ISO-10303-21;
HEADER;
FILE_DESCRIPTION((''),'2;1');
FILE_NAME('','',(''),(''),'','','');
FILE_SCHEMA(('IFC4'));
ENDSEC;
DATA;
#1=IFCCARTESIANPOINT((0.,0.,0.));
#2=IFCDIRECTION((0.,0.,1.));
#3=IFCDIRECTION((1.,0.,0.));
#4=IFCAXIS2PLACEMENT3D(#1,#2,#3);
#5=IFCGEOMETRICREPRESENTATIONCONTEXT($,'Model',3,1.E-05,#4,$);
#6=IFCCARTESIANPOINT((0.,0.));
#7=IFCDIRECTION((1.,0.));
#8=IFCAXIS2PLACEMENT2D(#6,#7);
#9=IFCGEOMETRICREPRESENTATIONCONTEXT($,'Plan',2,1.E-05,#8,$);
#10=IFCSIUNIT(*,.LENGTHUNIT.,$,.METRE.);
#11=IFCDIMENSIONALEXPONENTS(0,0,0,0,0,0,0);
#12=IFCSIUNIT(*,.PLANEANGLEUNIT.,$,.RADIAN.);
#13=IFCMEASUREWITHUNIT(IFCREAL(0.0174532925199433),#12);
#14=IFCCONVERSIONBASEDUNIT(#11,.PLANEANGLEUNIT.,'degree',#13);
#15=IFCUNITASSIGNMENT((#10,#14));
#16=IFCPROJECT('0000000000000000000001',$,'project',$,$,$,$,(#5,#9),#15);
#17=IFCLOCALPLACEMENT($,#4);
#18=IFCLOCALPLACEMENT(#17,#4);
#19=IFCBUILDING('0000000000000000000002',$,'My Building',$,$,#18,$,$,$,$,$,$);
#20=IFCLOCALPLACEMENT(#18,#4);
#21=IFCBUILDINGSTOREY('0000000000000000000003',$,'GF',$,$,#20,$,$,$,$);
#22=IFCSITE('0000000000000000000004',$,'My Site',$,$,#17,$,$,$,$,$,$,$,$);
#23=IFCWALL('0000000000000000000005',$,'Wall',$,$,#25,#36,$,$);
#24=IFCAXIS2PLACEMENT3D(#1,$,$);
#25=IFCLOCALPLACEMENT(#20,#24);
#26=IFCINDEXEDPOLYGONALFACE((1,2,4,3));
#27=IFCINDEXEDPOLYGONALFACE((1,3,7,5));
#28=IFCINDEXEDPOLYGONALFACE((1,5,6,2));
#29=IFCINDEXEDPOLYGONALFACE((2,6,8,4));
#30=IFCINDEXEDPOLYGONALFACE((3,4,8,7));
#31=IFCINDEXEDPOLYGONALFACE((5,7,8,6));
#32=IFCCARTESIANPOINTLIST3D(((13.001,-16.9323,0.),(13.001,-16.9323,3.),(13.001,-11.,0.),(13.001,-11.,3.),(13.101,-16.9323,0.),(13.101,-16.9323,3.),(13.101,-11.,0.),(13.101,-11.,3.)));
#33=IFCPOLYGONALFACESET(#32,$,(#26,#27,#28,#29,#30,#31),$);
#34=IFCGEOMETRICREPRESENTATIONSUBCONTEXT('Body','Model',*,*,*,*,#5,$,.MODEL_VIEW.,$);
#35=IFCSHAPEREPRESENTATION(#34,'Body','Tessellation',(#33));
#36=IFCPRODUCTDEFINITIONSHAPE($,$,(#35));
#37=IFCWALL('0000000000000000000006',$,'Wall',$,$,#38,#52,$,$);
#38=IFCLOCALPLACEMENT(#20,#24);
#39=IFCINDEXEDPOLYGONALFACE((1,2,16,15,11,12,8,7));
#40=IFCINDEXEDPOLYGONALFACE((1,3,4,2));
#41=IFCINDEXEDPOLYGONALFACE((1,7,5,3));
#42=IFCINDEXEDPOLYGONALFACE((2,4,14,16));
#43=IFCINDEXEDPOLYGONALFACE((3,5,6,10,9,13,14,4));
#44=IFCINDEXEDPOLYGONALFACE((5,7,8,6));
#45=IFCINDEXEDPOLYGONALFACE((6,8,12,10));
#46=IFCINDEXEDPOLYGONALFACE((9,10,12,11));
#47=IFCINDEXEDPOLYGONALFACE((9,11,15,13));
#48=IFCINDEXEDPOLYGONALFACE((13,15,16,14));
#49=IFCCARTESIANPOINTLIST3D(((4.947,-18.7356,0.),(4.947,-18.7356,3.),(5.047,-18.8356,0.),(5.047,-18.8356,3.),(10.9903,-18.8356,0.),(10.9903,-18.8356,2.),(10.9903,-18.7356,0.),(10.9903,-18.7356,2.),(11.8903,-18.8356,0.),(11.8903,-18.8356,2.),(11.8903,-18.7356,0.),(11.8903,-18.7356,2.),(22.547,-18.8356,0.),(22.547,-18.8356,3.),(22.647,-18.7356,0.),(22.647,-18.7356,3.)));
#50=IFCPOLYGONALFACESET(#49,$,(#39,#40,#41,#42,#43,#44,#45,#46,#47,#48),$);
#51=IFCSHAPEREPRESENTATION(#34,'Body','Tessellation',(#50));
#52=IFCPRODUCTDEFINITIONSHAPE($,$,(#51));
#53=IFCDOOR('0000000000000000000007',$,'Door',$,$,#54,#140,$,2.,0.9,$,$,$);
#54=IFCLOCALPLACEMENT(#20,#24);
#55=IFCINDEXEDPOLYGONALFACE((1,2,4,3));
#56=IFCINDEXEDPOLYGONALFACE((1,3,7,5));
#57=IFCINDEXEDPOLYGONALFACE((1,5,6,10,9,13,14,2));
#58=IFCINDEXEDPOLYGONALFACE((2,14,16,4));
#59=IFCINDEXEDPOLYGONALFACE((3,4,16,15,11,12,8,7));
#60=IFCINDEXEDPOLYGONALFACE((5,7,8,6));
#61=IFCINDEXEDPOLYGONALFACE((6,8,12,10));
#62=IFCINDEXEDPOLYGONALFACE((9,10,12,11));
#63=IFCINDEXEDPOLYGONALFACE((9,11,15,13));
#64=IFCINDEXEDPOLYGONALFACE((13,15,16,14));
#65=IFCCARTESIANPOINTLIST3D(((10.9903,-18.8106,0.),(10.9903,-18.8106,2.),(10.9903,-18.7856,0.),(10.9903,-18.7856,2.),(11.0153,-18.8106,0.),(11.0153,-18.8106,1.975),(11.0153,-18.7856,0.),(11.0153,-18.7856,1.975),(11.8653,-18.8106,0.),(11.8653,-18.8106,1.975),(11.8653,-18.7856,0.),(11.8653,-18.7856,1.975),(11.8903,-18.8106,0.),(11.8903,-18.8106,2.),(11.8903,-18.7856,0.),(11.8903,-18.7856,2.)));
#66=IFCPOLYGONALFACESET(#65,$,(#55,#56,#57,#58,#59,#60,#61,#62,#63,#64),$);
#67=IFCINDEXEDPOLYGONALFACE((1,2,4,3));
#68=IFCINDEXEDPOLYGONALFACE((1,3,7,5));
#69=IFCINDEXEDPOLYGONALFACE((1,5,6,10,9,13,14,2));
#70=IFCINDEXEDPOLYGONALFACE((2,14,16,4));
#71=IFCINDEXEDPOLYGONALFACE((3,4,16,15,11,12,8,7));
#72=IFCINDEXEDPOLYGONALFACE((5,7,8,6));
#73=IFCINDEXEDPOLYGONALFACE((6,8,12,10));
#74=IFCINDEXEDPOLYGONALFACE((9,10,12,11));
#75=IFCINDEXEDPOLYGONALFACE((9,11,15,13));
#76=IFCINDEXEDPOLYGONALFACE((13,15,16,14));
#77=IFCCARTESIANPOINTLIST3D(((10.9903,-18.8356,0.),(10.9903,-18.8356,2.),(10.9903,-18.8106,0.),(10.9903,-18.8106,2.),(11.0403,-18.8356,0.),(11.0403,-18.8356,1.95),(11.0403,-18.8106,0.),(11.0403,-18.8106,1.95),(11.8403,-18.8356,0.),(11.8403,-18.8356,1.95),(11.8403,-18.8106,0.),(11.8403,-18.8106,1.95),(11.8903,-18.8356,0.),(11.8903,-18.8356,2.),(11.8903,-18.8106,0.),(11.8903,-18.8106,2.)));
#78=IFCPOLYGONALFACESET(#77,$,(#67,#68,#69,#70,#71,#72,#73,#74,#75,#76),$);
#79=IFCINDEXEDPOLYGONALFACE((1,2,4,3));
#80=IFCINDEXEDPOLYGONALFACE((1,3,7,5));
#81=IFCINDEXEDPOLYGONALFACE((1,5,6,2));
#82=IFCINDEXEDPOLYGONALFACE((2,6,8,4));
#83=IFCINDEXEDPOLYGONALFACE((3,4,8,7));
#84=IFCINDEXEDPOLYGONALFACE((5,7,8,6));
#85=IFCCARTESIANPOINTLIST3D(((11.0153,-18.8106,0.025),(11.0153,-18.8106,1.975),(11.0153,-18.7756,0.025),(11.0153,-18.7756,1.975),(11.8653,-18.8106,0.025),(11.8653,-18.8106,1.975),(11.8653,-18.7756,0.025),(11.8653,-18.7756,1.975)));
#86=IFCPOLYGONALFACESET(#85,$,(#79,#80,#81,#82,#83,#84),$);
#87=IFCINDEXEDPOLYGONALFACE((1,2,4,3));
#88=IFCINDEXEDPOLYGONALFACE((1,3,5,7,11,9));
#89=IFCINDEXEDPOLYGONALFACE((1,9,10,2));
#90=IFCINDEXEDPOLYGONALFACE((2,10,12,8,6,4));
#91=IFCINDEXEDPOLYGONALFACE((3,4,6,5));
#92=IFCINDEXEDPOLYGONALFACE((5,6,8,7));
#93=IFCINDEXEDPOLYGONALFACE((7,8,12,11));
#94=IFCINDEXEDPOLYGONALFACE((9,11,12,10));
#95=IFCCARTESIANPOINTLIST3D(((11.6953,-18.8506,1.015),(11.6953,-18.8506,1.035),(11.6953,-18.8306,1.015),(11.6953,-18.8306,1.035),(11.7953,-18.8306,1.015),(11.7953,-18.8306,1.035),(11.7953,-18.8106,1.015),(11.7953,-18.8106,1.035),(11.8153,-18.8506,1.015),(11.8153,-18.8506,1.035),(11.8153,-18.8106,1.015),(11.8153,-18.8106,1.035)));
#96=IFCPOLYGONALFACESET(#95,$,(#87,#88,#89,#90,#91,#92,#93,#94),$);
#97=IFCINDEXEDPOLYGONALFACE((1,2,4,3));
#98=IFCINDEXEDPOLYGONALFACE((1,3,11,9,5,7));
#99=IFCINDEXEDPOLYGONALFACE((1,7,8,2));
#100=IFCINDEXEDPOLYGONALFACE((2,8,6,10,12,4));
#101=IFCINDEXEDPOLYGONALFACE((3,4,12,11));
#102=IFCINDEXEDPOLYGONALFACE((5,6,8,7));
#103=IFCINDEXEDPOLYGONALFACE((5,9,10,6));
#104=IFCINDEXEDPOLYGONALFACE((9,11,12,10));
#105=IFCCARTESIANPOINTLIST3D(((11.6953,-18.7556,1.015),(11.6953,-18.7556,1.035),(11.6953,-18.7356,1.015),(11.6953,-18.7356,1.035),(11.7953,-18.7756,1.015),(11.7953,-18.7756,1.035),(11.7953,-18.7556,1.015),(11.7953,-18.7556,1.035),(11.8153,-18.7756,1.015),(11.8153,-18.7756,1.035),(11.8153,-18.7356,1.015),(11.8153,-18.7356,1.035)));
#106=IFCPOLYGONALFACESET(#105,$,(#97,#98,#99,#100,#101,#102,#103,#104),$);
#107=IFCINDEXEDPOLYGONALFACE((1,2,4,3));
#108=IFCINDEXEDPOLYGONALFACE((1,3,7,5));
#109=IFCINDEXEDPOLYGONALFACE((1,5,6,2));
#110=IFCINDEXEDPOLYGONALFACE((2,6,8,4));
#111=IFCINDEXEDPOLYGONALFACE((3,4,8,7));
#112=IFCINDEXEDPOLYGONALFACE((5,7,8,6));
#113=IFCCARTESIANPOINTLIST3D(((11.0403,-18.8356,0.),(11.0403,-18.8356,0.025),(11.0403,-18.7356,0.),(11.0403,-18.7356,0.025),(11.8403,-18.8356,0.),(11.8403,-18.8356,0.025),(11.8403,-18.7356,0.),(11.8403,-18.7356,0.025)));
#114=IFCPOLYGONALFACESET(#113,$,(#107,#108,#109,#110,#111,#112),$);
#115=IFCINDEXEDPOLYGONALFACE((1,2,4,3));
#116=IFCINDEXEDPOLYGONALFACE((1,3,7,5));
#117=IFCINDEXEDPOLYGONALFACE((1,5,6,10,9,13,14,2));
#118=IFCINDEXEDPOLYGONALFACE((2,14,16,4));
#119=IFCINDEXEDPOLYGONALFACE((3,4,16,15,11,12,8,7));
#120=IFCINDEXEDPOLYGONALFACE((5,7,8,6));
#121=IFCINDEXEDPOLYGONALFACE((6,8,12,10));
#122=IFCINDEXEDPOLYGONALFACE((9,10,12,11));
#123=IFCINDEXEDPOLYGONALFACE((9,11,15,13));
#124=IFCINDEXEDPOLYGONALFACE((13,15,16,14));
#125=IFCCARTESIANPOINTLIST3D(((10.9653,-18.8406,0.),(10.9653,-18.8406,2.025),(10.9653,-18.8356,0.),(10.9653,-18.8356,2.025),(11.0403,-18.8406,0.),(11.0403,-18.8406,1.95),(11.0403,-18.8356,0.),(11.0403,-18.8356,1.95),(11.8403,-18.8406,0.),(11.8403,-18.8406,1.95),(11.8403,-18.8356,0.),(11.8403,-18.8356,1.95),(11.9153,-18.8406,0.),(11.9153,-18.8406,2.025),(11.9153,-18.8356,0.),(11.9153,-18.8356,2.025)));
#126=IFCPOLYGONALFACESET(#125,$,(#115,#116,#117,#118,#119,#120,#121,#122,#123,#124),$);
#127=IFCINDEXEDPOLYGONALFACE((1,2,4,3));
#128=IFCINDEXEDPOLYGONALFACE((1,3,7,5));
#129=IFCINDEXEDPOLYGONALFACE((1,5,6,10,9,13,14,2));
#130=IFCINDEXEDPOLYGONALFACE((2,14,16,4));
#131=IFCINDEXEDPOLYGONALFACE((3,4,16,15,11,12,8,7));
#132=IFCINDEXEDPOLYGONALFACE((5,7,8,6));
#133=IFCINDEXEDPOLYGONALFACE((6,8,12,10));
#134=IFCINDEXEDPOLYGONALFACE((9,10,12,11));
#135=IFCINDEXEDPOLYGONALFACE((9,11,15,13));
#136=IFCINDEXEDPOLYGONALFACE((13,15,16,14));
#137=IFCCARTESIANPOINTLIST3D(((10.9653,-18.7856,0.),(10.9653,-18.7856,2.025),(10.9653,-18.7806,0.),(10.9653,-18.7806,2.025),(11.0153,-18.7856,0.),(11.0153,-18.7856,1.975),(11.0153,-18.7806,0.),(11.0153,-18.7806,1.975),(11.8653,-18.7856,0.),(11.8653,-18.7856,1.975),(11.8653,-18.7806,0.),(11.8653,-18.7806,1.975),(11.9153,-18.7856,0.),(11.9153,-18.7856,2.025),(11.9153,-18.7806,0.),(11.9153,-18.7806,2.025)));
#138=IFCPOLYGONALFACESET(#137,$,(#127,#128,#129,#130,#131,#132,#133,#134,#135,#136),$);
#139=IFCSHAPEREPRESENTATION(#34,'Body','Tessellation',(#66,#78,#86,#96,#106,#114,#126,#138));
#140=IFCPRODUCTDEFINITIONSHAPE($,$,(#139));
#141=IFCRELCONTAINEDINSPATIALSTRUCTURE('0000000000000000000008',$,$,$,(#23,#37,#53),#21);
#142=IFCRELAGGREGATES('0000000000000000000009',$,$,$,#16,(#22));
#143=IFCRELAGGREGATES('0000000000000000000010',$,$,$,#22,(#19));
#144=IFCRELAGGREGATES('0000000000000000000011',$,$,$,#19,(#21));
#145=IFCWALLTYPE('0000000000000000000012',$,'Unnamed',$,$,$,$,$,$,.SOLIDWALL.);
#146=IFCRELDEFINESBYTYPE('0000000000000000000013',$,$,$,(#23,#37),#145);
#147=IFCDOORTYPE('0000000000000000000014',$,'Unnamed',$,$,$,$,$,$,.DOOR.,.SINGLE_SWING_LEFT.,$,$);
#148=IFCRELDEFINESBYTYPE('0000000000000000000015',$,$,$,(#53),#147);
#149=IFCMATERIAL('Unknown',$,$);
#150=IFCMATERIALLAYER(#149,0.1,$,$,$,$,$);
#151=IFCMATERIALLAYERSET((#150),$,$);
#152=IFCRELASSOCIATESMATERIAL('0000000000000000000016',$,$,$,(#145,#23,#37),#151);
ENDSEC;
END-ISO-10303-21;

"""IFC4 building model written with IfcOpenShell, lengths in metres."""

from ifc_helpers import new_model, entity, si_unit, converted_unit, frame, origin_with_axes, origin_2d_with_axis, place, context, subcontext, project, spatial, line, indexed_curve, outline, extrude, shape, source, transform, mapped, material, layer, layer_set, layer_usage, type_object, type_shapes, element, fill, save


model = new_model("IFC4")

# Units and contexts
model_context = context("Model", 3, precision=1e-05, world=origin_with_axes())
plan_context = context("Plan", 2, precision=1e-05, world=origin_2d_with_axis())
body_context_1 = subcontext(model_context, "Body", "Model", "MODEL_VIEW")
body_context_2 = subcontext(plan_context, "Body", "Plan", "PLAN_VIEW")
ifc_project = project(units=[si_unit("LENGTHUNIT", "METRE"), converted_unit("PLANEANGLEUNIT", "degree", entity("IfcReal", 0.0174532925199433), si_unit("PLANEANGLEUNIT", "RADIAN"), dimensions=[0, 0, 0, 0, 0, 0, 0])], contexts=[model_context, plan_context])

# Site, building, storey
site_placement = place(None, origin_with_axes())
site = spatial("IfcSite", under=ifc_project, at=site_placement, Name="My Site")
building_placement = place(site_placement, origin_with_axes())
building = spatial("IfcBuilding", under=site, at=building_placement, Name="My Building")
storey_placement = place(building_placement, origin_with_axes())
storey = spatial("IfcBuildingStorey", under=building, at=storey_placement, Name="GF")

# Shared definitions
ifc_material = material(Name="Unknown")

# Shared definitions
ifc_layer_1 = layer(ifc_material, 0.1)
ifc_layer_set_1 = layer_set([ifc_layer_1])
wall_type = type_object("IfcWallType", Name="Unnamed", PredefinedType="SOLIDWALL", material=ifc_layer_set_1)

# Shared definitions
shared_shape_1 = source(origin_with_axes(), body_context_1, "Body", "SweptSolid", [
    extrude(outline(indexed_curve([(0.0, 0.0), (0.9, 0.0), (0.9, 2.0), (0.0, 2.0)], segments=[line(1, 2, 3, 4, 1)])), frame((0.0, -0.6, 0.0), z_axis=(0.0, -1.0, 0.0), x_axis=(1.0, 0.0, 0.0)), (0.0, 0.0, -1.0), 1.2),
])
door_type = type_object("IfcDoorType", Name="Unnamed", OperationType="SINGLE_SWING_LEFT", PredefinedType="DOOR")
shared_shape_2 = source(origin_with_axes(), body_context_1, "Body", "SweptSolid", [
    extrude(outline(indexed_curve([(0.0, 0.0), (0.0, 2.0), (0.9, 2.0), (0.9, 0.0), (0.875, 0.0), (0.875, 1.975), (0.025, 1.975), (0.025, 0.0)], segments=[line(1, 2, 3, 4, 5, 6, 7, 8, 1)])), frame((0.0, 0.025, 0.0), z_axis=(0.0, -1.0, 0.0), x_axis=(1.0, 0.0, 0.0)), (0.0, 0.0, -1.0), 0.025),
    extrude(outline(indexed_curve([(0.0, 0.0), (0.0, 2.0), (0.9, 2.0), (0.9, 0.0), (0.85, 0.0), (0.85, 1.95), (0.05, 1.95), (0.05, 0.0)], segments=[line(1, 2, 3, 4, 5, 6, 7, 8, 1)])), frame((0.0, 0.0, 0.0), z_axis=(0.0, -1.0, 0.0), x_axis=(1.0, 0.0, 0.0)), (0.0, 0.0, -1.0), 0.025),
    extrude(outline(indexed_curve([(0.0, 0.0), (0.85, 0.0), (0.85, 0.035), (0.0, 0.035)], segments=[line(1, 2, 3, 4, 1)])), frame((0.025, 0.025, 0.025), z_axis=(0.0, 0.0, 1.0), x_axis=(1.0, 0.0, 0.0)), (0.0, 0.0, 1.0), 1.95),
    extrude(outline(indexed_curve([(0.0, 0.0), (0.0, -0.04), (-0.12, -0.04), (-0.12, -0.02), (-0.02, -0.02), (-0.02, 0.0)], segments=[line(1, 2, 3, 4, 5, 6, 1)])), frame((0.825, 0.025, 1.015), z_axis=(0.0, 0.0, 1.0), x_axis=(1.0, 0.0, 0.0)), (0.0, 0.0, 1.0), 0.02),
    extrude(outline(indexed_curve([(0.0, 0.0), (0.0, 0.04), (-0.12, 0.04), (-0.12, 0.02), (-0.02, 0.02), (-0.02, 0.0)], segments=[line(1, 2, 3, 4, 5, 6, 1)])), frame((0.825, 0.06, 1.015), z_axis=(0.0, 0.0, 1.0), x_axis=(1.0, 0.0, 0.0)), (0.0, 0.0, 1.0), 0.02),
    extrude(outline(indexed_curve([(0.0, 0.0), (0.8, 0.0), (0.8, 0.1), (0.0, 0.1)], segments=[line(1, 2, 3, 4, 1)])), frame((0.05, 0.0, 0.0), z_axis=(0.0, 0.0, 1.0), x_axis=(1.0, 0.0, 0.0)), (0.0, 0.0, 1.0), 0.025),
    extrude(outline(indexed_curve([(0.0, 0.0), (0.0, 2.025), (0.95, 2.025), (0.95, 0.0), (0.875, 0.0), (0.875, 1.95), (0.075, 1.95), (0.075, 0.0)], segments=[line(1, 2, 3, 4, 5, 6, 7, 8, 1)])), frame((-0.025, -0.005, 0.0), z_axis=(0.0, -1.0, 0.0), x_axis=(1.0, 0.0, 0.0)), (0.0, 0.0, -1.0), 0.005),
    extrude(outline(indexed_curve([(0.0, 0.0), (0.0, 2.025), (0.95, 2.025), (0.95, 0.0), (0.9, 0.0), (0.9, 1.975), (0.05, 1.975), (0.05, 0.0)], segments=[line(1, 2, 3, 4, 5, 6, 7, 8, 1)])), frame((-0.025, 0.05, 0.0), z_axis=(0.0, -1.0, 0.0), x_axis=(1.0, 0.0, 0.0)), (0.0, 0.0, -1.0), 0.005),
])
shared_shape_3 = source(origin_with_axes(), body_context_2, "Body", "Curve2D", [
    entity("IfcIndexedPolyCurve", entity("IfcCartesianPointList2D", [[0.0, 0.0], [0.0, 0.05], [0.025, 0.05], [0.025, 0.025], [0.05, 0.025], [0.05, 0.0]]), [entity("IfcLineIndex", [1, 2, 3, 4, 5, 6, 1])]),
    entity("IfcIndexedPolyCurve", entity("IfcCartesianPointList2D", [[0.9, 0.0], [0.9, 0.05], [0.875, 0.05], [0.875, 0.025], [0.85, 0.025], [0.85, 0.0]]), [entity("IfcLineIndex", [1, 2, 3, 4, 5, 6, 1])]),
    entity("IfcTrimmedCurve", entity("IfcEllipse", entity("IfcAxis2Placement2D", entity("IfcCartesianPoint", [0.06, 0.05]), entity("IfcDirection", [1.0, 0.0])), 0.815, 0.85), [entity("IfcCartesianPoint", [0.875, 0.05])], [entity("IfcCartesianPoint", [0.06, 0.9])], True, "CARTESIAN"),
    entity("IfcIndexedPolyCurve", entity("IfcCartesianPointList2D", [[0.025, 0.05], [0.06, 0.05], [0.06, 0.9], [0.025, 0.9]]), [entity("IfcLineIndex", [1, 2, 3, 4, 1])]),
])
type_shapes(door_type, [shared_shape_2, shared_shape_3])

# Wall
ifc_layer_usage_1 = layer_usage(ifc_layer_set_1, "AXIS2", "POSITIVE", 0.0)
wall_1_placement = place(storey_placement, frame((13.101, -16.9323, 0.0), z_axis=(0.0, 0.0, 1.0), x_axis=(0.0, 1.0, 0.0)))
element("IfcWall", 1, at=wall_1_placement, inside=storey, type_object=wall_type, material=ifc_layer_usage_1, Name="Wall", context=body_context_1, shape_type="SweptSolid", body=[
    extrude(outline(indexed_curve([(0.0, 0.0), (0.0, 0.1), (5.9323, 0.1), (5.9323, 0.0)], segments=[line(1, 2, 3, 4, 1)])), origin_with_axes(), (0.0, 0.0, 1.0), 3.0),
])

# Wall, opening, door
ifc_layer_usage_2 = layer_usage(ifc_layer_set_1, "AXIS2", "POSITIVE", 0.0)
wall_2_placement = place(storey_placement, frame((5.047, -18.8356, 0.0), z_axis=(0.0, 0.0, 1.0), x_axis=(1.0, 0.0, 0.0)))
wall_2 = element("IfcWall", 2, at=wall_2_placement, inside=storey, type_object=wall_type, material=ifc_layer_usage_2, Name="Wall", context=body_context_1, shape_type="SweptSolid", body=[
    extrude(outline(indexed_curve([(0.0, 0.0), (-0.1, 0.1), (17.6, 0.1), (17.5, 0.0)], segments=[line(1, 2, 3, 4, 1)])), origin_with_axes(), (0.0, 0.0, 1.0), 3.0),
])
opening_1_placement = place(wall_2_placement, frame((5.9433, 0.0, 0.0), z_axis=(0.0, 0.0, 1.0), x_axis=(1.0, 0.0, 0.0)))
opening_1 = element("IfcOpeningElement", 3, at=opening_1_placement, cuts=wall_2, PredefinedType="OPENING", context=body_context_1, shape_type="MappedRepresentation", body=[
    mapped(shared_shape_1, transform((0.0, 0.0, 0.0), x_axis=(1.0, 0.0, 0.0), y_axis=(0.0, 1.0, 0.0), z_axis=(0.0, 0.0, 1.0), scale=1.0)),
])
door_1_placement = place(opening_1_placement, origin_with_axes())
door_1 = element("IfcDoor", 4, at=door_1_placement, inside=storey, type_object=door_type, Name="Door", OverallHeight=2.0, OverallWidth=0.9, shapes=[
    shape(body_context_1, "Body", "MappedRepresentation", [mapped(shared_shape_2, transform((0.0, 0.0, 0.0), x_axis=(1.0, 0.0, 0.0), y_axis=(0.0, 1.0, 0.0), z_axis=(0.0, 0.0, 1.0), scale=1.0))]),
    shape(body_context_2, "Body", "MappedRepresentation", [mapped(shared_shape_3, transform((0.0, 0.0, 0.0), x_axis=(1.0, 0.0, 0.0), y_axis=(0.0, 1.0, 0.0), z_axis=(0.0, 0.0, 1.0), scale=1.0))]),
])
fill(opening_1, door_1)

save(model, "model.ifc")
